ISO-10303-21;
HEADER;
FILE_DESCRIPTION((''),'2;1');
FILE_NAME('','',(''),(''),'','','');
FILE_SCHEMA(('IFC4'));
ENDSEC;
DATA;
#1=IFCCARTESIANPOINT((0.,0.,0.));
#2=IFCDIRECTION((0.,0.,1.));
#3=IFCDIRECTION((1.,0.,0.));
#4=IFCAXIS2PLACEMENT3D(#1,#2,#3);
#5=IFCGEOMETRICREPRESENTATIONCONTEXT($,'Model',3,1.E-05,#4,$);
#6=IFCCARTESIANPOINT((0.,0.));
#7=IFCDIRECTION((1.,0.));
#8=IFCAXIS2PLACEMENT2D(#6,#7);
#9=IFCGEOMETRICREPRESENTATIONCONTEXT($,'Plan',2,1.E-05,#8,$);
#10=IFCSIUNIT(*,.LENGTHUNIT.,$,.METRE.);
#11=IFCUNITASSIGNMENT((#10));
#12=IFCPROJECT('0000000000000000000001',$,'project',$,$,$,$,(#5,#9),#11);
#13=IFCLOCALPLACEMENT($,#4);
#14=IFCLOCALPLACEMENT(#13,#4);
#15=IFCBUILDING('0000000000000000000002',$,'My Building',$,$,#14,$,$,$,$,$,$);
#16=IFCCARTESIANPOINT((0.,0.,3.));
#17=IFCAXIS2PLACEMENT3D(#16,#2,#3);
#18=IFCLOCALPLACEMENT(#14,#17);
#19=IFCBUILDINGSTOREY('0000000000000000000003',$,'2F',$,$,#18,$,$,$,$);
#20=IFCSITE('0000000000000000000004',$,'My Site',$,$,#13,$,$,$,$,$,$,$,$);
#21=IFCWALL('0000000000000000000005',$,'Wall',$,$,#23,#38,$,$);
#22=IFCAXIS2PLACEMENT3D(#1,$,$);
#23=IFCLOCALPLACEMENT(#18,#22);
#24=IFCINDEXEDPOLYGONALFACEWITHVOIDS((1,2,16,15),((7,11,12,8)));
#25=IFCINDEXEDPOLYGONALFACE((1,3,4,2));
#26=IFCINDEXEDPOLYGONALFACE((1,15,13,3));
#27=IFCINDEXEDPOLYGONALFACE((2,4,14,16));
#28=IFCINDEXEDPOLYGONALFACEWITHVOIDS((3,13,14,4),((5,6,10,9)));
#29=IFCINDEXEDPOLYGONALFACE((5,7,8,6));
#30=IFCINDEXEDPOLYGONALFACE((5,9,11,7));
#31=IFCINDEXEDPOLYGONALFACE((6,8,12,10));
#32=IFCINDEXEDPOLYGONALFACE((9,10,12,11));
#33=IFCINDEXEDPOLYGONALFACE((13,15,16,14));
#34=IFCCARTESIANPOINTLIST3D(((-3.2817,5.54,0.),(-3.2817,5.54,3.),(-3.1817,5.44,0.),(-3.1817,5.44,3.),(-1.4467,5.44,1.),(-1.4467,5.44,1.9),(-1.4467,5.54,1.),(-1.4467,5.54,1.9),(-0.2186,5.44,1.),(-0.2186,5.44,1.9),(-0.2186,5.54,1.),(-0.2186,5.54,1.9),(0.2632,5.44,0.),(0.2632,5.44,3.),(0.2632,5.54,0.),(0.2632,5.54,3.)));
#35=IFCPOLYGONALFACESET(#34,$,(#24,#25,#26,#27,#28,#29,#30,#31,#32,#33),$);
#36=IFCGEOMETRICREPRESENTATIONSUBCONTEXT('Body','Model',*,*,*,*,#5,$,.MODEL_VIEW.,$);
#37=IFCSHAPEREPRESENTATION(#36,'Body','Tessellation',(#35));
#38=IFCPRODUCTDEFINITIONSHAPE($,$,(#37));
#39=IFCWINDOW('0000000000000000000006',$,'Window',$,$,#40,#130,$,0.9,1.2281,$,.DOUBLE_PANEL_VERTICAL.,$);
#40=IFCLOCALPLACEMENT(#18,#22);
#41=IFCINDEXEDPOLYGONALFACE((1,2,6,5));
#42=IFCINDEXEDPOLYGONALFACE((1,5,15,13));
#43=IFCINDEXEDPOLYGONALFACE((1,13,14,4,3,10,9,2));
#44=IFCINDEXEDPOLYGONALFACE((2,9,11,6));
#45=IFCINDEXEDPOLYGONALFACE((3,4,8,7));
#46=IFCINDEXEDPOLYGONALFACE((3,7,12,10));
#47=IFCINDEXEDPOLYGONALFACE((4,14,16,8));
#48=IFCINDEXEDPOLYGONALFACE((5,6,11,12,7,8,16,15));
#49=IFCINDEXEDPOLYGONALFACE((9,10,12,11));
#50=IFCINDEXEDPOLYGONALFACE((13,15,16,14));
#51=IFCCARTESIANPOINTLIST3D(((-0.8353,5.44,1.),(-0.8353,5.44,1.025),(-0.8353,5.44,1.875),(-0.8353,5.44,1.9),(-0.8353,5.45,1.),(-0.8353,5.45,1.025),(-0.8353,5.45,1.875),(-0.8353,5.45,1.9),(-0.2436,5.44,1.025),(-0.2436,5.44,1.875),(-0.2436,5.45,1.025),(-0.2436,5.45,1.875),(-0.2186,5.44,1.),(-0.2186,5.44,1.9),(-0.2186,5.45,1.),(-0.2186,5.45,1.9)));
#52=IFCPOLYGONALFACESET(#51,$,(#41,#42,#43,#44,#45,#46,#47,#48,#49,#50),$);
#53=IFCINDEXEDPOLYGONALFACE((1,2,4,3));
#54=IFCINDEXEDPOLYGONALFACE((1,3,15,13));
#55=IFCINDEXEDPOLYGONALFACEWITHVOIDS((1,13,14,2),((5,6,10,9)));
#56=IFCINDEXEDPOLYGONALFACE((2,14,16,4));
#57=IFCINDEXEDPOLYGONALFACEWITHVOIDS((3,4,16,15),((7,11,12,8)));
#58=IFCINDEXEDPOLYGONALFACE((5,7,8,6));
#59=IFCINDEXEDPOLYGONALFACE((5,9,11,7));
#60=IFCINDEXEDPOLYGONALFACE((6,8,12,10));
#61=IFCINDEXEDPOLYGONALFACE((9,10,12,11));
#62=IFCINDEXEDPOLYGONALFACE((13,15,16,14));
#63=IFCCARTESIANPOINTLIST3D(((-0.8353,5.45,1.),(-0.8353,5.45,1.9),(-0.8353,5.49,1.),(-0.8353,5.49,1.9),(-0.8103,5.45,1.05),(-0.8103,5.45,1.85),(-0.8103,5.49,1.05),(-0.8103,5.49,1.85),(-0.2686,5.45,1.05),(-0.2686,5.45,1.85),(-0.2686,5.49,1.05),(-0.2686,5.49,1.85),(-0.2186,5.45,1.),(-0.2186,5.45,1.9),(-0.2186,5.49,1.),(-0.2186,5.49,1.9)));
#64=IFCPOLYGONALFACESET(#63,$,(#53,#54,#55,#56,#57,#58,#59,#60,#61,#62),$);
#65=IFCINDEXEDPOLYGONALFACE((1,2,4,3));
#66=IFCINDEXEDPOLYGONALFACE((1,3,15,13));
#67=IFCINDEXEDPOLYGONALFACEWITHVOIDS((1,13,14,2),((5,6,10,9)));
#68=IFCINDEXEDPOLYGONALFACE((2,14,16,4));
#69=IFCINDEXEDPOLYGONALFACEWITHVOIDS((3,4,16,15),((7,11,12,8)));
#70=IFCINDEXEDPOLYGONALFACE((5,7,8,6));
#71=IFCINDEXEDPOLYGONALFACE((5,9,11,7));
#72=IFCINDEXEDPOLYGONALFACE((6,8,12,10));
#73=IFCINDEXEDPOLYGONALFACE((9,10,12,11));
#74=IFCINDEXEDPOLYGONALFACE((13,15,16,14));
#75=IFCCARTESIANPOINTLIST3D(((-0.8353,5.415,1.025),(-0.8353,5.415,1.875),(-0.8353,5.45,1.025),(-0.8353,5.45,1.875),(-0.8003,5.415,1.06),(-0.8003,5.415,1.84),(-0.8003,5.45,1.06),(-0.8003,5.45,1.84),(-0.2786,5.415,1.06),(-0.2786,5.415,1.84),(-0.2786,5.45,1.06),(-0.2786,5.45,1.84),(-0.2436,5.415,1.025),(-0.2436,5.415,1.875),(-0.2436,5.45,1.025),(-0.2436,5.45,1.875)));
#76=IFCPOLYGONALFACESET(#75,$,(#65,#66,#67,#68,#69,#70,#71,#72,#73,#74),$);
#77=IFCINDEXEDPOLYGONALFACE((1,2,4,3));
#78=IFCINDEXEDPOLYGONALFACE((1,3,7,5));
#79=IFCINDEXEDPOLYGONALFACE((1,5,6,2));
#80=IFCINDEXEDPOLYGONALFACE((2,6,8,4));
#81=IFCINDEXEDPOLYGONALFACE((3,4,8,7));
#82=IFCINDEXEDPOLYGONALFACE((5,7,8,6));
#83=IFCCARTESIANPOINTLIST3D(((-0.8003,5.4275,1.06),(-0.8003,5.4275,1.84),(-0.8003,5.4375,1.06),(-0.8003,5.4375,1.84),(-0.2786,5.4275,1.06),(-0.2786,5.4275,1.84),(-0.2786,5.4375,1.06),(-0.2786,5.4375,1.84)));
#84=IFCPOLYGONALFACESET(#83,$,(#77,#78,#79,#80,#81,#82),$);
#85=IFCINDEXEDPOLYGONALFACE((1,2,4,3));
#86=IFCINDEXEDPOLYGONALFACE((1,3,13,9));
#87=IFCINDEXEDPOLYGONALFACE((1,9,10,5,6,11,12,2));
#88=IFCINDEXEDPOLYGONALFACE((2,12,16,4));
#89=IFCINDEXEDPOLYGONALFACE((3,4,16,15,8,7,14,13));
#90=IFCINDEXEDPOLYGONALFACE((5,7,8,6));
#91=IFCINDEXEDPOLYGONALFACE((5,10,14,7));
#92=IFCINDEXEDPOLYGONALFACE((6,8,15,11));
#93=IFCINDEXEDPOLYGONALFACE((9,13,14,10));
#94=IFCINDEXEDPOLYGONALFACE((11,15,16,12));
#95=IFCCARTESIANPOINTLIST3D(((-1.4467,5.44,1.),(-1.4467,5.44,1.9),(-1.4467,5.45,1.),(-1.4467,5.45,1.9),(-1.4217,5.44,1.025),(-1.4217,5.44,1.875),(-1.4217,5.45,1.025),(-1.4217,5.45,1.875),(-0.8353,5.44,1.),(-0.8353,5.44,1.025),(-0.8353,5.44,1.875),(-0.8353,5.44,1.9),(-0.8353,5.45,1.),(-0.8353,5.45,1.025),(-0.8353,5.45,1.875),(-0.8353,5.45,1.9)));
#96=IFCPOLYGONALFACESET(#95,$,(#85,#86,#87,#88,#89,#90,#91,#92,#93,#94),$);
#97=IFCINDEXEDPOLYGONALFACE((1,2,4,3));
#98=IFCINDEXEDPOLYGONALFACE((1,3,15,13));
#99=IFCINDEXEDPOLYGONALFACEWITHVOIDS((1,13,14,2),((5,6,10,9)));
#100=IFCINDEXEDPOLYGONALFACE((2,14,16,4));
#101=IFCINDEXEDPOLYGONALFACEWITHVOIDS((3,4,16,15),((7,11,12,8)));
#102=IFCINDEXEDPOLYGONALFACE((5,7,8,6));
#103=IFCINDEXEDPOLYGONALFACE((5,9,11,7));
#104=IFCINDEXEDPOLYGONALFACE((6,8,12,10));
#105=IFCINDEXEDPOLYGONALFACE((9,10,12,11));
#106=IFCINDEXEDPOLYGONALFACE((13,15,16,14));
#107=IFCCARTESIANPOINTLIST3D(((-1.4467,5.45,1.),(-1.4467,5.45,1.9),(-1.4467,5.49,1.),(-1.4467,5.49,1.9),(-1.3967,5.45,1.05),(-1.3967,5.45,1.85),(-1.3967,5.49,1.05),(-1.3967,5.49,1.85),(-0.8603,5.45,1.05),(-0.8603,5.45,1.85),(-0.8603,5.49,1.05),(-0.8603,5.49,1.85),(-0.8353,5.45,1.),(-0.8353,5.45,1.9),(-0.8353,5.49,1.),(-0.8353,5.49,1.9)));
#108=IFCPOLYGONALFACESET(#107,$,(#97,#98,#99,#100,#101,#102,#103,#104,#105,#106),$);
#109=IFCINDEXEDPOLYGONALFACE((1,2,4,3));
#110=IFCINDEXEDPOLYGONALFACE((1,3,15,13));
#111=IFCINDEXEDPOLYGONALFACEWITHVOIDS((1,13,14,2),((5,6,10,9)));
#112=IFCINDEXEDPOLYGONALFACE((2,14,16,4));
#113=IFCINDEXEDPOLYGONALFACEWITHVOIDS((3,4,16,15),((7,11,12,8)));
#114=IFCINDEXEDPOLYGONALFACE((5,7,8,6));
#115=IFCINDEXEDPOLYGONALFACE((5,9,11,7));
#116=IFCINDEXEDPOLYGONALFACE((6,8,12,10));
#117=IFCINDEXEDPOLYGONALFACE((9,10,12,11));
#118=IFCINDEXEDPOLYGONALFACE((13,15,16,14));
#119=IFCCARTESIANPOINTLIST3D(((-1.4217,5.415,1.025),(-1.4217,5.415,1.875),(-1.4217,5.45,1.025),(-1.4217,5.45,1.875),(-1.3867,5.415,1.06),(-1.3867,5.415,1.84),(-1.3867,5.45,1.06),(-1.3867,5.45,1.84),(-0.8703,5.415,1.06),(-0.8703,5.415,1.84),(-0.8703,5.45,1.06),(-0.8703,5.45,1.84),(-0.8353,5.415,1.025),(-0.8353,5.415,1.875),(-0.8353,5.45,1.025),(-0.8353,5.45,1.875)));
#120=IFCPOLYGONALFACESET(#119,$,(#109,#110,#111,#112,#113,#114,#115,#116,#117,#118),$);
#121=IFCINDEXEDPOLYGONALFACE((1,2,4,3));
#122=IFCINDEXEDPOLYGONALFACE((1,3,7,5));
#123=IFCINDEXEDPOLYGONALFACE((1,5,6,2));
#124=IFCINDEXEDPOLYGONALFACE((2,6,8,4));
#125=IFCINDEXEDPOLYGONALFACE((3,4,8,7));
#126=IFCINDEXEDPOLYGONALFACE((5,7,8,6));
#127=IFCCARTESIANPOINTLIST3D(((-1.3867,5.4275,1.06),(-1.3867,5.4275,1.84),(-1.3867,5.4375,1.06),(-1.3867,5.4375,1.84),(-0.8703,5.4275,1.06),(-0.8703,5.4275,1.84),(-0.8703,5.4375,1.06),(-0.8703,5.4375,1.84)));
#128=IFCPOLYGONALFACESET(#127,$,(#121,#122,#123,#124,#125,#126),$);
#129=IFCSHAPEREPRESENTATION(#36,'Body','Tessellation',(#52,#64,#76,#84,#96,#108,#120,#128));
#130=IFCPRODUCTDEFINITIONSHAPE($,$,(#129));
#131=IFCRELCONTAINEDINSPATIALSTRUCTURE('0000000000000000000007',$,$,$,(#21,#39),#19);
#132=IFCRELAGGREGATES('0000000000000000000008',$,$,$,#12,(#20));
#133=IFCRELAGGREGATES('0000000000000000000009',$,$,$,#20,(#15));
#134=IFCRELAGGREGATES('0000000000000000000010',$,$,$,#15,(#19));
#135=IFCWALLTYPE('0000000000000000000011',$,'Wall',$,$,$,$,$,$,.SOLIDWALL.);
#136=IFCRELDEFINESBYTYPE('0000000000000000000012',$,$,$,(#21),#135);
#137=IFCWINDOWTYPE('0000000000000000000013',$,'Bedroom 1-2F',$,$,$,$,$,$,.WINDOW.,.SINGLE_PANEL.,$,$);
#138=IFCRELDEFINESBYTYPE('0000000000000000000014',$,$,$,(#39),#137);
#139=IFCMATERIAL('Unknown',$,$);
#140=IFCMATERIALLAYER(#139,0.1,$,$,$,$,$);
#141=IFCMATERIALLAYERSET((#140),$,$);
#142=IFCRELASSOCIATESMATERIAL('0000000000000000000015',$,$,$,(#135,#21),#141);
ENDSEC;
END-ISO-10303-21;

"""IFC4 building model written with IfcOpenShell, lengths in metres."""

from ifc_helpers import new_model, entity, si_unit, frame, origin_with_axes, origin_2d_with_axis, place, context, subcontext, project, spatial, line, indexed_curve, outline, extrude, shape, source, transform, mapped, material, layer, layer_set, layer_usage, type_object, type_shapes, element, fill, save


model = new_model("IFC4")

# Units and contexts
model_context_1 = context("Model", 3, precision=1e-05, world=origin_with_axes())
plan_context = context("Plan", 2, precision=1e-05, world=origin_2d_with_axis())
body_context_1 = subcontext(model_context_1, "Body", "Model", "MODEL_VIEW")
body_context_2 = subcontext(plan_context, "Body", "Plan", "PLAN_VIEW")
ifc_project = project(units=[si_unit("LENGTHUNIT", "METRE")], contexts=[model_context_1, plan_context])

# Site, building, storey
site_placement = place(None, origin_with_axes())
site = spatial("IfcSite", under=ifc_project, at=site_placement, Name="My Site")
building_placement = place(site_placement, origin_with_axes())
building = spatial("IfcBuilding", under=site, at=building_placement, Name="My Building")
storey_placement = place(building_placement, frame((0.0, 0.0, 3.0), z_axis=(0.0, 0.0, 1.0), x_axis=(1.0, 0.0, 0.0)))
storey = spatial("IfcBuildingStorey", under=building, at=storey_placement, Name="2F")

# Shared definitions
ifc_material = material(Name="Unknown")

# Shared definitions
ifc_layer_1 = layer(ifc_material, 0.1)
ifc_layer_set_1 = layer_set([ifc_layer_1])
wall_type = type_object("IfcWallType", Name="Wall", PredefinedType="SOLIDWALL", material=ifc_layer_set_1)

# Wall, opening, window
ifc_layer_usage_1 = layer_usage(ifc_layer_set_1, "AXIS2", "POSITIVE", 0.0)
wall_1_placement = place(storey_placement, frame((0.2632, 5.54, 0.0), z_axis=(0.0, 0.0, 1.0), x_axis=(-1.0, 0.0, 0.0)))
wall_1 = element("IfcWall", 1, at=wall_1_placement, inside=storey, type_object=wall_type, material=ifc_layer_usage_1, Name="Wall", context=body_context_1, shape_type="SweptSolid", body=[
    extrude(outline(indexed_curve([(0.0, 0.0), (0.0, 0.1), (3.4448, 0.1), (3.5448, 0.0)], segments=[line(1, 2, 3, 4, 1)])), origin_with_axes(), (0.0, 0.0, 1.0), 3.0),
])
shared_shape_1 = source(origin_with_axes(), body_context_1, "Body", "SweptSolid", [
    extrude(outline(indexed_curve([(0.0, 0.0), (1.2281, 0.0), (1.2281, 0.9), (0.0, 0.9)], segments=[line(1, 2, 3, 4, 1)])), frame((0.0, -0.6, 0.0), z_axis=(0.0, -1.0, 0.0), x_axis=(1.0, 0.0, 0.0)), (0.0, 0.0, -1.0), 1.2),
])
opening_1_placement = place(wall_1_placement, frame((0.4818, 0.0, 1.0), z_axis=(0.0, 0.0, 1.0), x_axis=(1.0, 0.0, 0.0)))
opening_1 = element("IfcOpeningElement", 2, at=opening_1_placement, cuts=wall_1, PredefinedType="OPENING", context=body_context_1, shape_type="MappedRepresentation", body=[
    mapped(shared_shape_1, transform((0.0, 0.0, 0.0), x_axis=(1.0, 0.0, 0.0), y_axis=(0.0, 1.0, 0.0), z_axis=(0.0, 0.0, 1.0), scale=1.0)),
])
window_type_1 = type_object("IfcWindowType", Name="Bedroom 1-2F", PartitioningType="SINGLE_PANEL", PredefinedType="WINDOW")
shared_shape_2 = source(origin_with_axes(), body_context_1, "Body", "SweptSolid", [
    extrude(outline(indexed_curve([(0.6167, 0.0), (0.0, 0.0), (0.0, 0.9), (0.6167, 0.9), (0.6167, 0.875), (0.025, 0.875), (0.025, 0.025), (0.6167, 0.025)], segments=[line(1, 2, 3, 4, 5, 6, 7, 8, 1)])), frame((0.0, 0.09, 0.0), z_axis=(0.0, -1.0, 0.0), x_axis=(1.0, 0.0, 0.0)), (0.0, 0.0, -1.0), 0.01),
    extrude(outline(indexed_curve([(0.0, 0.0), (0.6167, 0.0), (0.6167, 0.9), (0.0, 0.9)], segments=[line(1, 2, 3, 4, 1)]), holes=[indexed_curve([(0.05, 0.05), (0.5917, 0.05), (0.5917, 0.85), (0.05, 0.85)], segments=[line(1, 2, 3, 4, 1)])]), frame((0.0, 0.05, 0.0), z_axis=(0.0, -1.0, 0.0), x_axis=(1.0, 0.0, 0.0)), (0.0, 0.0, -1.0), 0.04),
    extrude(outline(indexed_curve([(0.0, 0.0), (0.5917, 0.0), (0.5917, 0.85), (0.0, 0.85)], segments=[line(1, 2, 3, 4, 1)]), holes=[indexed_curve([(0.035, 0.035), (0.5567, 0.035), (0.5567, 0.815), (0.035, 0.815)], segments=[line(1, 2, 3, 4, 1)])]), frame((0.025, 0.09, 0.025), z_axis=(0.0, -1.0, 0.0), x_axis=(1.0, 0.0, 0.0)), (0.0, 0.0, -1.0), 0.035),
    extrude(outline(indexed_curve([(0.035, 0.035), (0.5567, 0.035), (0.5567, 0.815), (0.035, 0.815)], segments=[line(1, 2, 3, 4, 1)])), frame((0.025, 0.1025, 0.025), z_axis=(0.0, -1.0, 0.0), x_axis=(1.0, 0.0, 0.0)), (0.0, 0.0, -1.0), 0.01),
    extrude(outline(indexed_curve([(0.0, 0.9), (0.6114, 0.9), (0.6114, 0.0), (0.0, 0.0), (0.0, 0.025), (0.5864, 0.025), (0.5864, 0.875), (0.0, 0.875)], segments=[line(1, 2, 3, 4, 5, 6, 7, 8, 1)])), frame((0.6167, 0.09, 0.0), z_axis=(0.0, -1.0, 0.0), x_axis=(1.0, 0.0, 0.0)), (0.0, 0.0, -1.0), 0.01),
    extrude(outline(indexed_curve([(0.0, 0.0), (0.6114, 0.0), (0.6114, 0.9), (0.0, 0.9)], segments=[line(1, 2, 3, 4, 1)]), holes=[indexed_curve([(0.025, 0.05), (0.5614, 0.05), (0.5614, 0.85), (0.025, 0.85)], segments=[line(1, 2, 3, 4, 1)])]), frame((0.6167, 0.05, 0.0), z_axis=(0.0, -1.0, 0.0), x_axis=(1.0, 0.0, 0.0)), (0.0, 0.0, -1.0), 0.04),
    extrude(outline(indexed_curve([(0.0, 0.0), (0.5864, 0.0), (0.5864, 0.85), (0.0, 0.85)], segments=[line(1, 2, 3, 4, 1)]), holes=[indexed_curve([(0.035, 0.035), (0.5514, 0.035), (0.5514, 0.815), (0.035, 0.815)], segments=[line(1, 2, 3, 4, 1)])]), frame((0.6167, 0.09, 0.025), z_axis=(0.0, -1.0, 0.0), x_axis=(1.0, 0.0, 0.0)), (0.0, 0.0, -1.0), 0.035),
    extrude(outline(indexed_curve([(0.035, 0.035), (0.5514, 0.035), (0.5514, 0.815), (0.035, 0.815)], segments=[line(1, 2, 3, 4, 1)])), frame((0.6167, 0.1025, 0.025), z_axis=(0.0, -1.0, 0.0), x_axis=(1.0, 0.0, 0.0)), (0.0, 0.0, -1.0), 0.01),
])
shared_shape_3 = source(origin_with_axes(), body_context_2, "Body", "Curve2D", [
    entity("IfcIndexedPolyCurve", entity("IfcCartesianPointList2D", [[0.05, 0.05], [0.5917, 0.05]])),
    entity("IfcIndexedPolyCurve", entity("IfcCartesianPointList2D", [[0.0, 0.1], [0.025, 0.1], [0.025, 0.09], [0.05, 0.09], [0.05, 0.05], [0.0, 0.05]]), [entity("IfcLineIndex", [1, 2, 3, 4, 5, 6, 1])]),
    entity("IfcIndexedPolyCurve", entity("IfcCartesianPointList2D", [[0.6167, 0.1], [0.6167, 0.1], [0.6167, 0.09], [0.5917, 0.09], [0.5917, 0.05], [0.6167, 0.05]])),
    entity("IfcIndexedPolyCurve", entity("IfcCartesianPointList2D", [[0.025, 0.09], [0.06, 0.09], [0.06, 0.125], [0.025, 0.125]]), [entity("IfcLineIndex", [1, 2, 3, 4, 1])]),
    entity("IfcIndexedPolyCurve", entity("IfcCartesianPointList2D", [[0.6167, 0.09], [0.5817, 0.09], [0.5817, 0.125], [0.6167, 0.125]]), [entity("IfcLineIndex", [1, 2, 3, 4, 1])]),
    entity("IfcIndexedPolyCurve", entity("IfcCartesianPointList2D", [[0.06, 0.09], [0.5817, 0.09]])),
    entity("IfcIndexedPolyCurve", entity("IfcCartesianPointList2D", [[0.06, 0.125], [0.5817, 0.125]])),
    entity("IfcIndexedPolyCurve", entity("IfcCartesianPointList2D", [[0.06, 0.1075], [0.5817, 0.1075]])),
    entity("IfcIndexedPolyCurve", entity("IfcCartesianPointList2D", [[0.6417, 0.05], [1.1781, 0.05]])),
    entity("IfcIndexedPolyCurve", entity("IfcCartesianPointList2D", [[0.6167, 0.1], [0.6167, 0.1], [0.6167, 0.09], [0.6417, 0.09], [0.6417, 0.05], [0.6167, 0.05]])),
    entity("IfcIndexedPolyCurve", entity("IfcCartesianPointList2D", [[1.2281, 0.1], [1.2031, 0.1], [1.2031, 0.09], [1.1781, 0.09], [1.1781, 0.05], [1.2281, 0.05]]), [entity("IfcLineIndex", [1, 2, 3, 4, 5, 6, 1])]),
    entity("IfcIndexedPolyCurve", entity("IfcCartesianPointList2D", [[0.6167, 0.09], [0.6517, 0.09], [0.6517, 0.125], [0.6167, 0.125]]), [entity("IfcLineIndex", [1, 2, 3, 4, 1])]),
    entity("IfcIndexedPolyCurve", entity("IfcCartesianPointList2D", [[1.2031, 0.09], [1.1681, 0.09], [1.1681, 0.125], [1.2031, 0.125]]), [entity("IfcLineIndex", [1, 2, 3, 4, 1])]),
    entity("IfcIndexedPolyCurve", entity("IfcCartesianPointList2D", [[0.6517, 0.09], [1.1681, 0.09]])),
    entity("IfcIndexedPolyCurve", entity("IfcCartesianPointList2D", [[0.6517, 0.125], [1.1681, 0.125]])),
    entity("IfcIndexedPolyCurve", entity("IfcCartesianPointList2D", [[0.6517, 0.1075], [1.1681, 0.1075]])),
])
type_shapes(window_type_1, [shared_shape_2, shared_shape_3])
window_1_placement = place(opening_1_placement, origin_with_axes())
window_1 = element("IfcWindow", 3, at=window_1_placement, inside=storey, type_object=window_type_1, Name="Window", OverallHeight=0.9, OverallWidth=1.2281, PartitioningType="DOUBLE_PANEL_VERTICAL", shapes=[
    shape(body_context_1, "Body", "MappedRepresentation", [mapped(shared_shape_2, transform((0.0, 0.0, 0.0), x_axis=(1.0, 0.0, 0.0), y_axis=(0.0, 1.0, 0.0), z_axis=(0.0, 0.0, 1.0), scale=1.0))]),
    shape(body_context_2, "Body", "MappedRepresentation", [mapped(shared_shape_3, transform((0.0, 0.0, 0.0), x_axis=(1.0, 0.0, 0.0), y_axis=(0.0, 1.0, 0.0), z_axis=(0.0, 0.0, 1.0), scale=1.0))]),
])
fill(opening_1, window_1)

save(model, "model.ifc")
